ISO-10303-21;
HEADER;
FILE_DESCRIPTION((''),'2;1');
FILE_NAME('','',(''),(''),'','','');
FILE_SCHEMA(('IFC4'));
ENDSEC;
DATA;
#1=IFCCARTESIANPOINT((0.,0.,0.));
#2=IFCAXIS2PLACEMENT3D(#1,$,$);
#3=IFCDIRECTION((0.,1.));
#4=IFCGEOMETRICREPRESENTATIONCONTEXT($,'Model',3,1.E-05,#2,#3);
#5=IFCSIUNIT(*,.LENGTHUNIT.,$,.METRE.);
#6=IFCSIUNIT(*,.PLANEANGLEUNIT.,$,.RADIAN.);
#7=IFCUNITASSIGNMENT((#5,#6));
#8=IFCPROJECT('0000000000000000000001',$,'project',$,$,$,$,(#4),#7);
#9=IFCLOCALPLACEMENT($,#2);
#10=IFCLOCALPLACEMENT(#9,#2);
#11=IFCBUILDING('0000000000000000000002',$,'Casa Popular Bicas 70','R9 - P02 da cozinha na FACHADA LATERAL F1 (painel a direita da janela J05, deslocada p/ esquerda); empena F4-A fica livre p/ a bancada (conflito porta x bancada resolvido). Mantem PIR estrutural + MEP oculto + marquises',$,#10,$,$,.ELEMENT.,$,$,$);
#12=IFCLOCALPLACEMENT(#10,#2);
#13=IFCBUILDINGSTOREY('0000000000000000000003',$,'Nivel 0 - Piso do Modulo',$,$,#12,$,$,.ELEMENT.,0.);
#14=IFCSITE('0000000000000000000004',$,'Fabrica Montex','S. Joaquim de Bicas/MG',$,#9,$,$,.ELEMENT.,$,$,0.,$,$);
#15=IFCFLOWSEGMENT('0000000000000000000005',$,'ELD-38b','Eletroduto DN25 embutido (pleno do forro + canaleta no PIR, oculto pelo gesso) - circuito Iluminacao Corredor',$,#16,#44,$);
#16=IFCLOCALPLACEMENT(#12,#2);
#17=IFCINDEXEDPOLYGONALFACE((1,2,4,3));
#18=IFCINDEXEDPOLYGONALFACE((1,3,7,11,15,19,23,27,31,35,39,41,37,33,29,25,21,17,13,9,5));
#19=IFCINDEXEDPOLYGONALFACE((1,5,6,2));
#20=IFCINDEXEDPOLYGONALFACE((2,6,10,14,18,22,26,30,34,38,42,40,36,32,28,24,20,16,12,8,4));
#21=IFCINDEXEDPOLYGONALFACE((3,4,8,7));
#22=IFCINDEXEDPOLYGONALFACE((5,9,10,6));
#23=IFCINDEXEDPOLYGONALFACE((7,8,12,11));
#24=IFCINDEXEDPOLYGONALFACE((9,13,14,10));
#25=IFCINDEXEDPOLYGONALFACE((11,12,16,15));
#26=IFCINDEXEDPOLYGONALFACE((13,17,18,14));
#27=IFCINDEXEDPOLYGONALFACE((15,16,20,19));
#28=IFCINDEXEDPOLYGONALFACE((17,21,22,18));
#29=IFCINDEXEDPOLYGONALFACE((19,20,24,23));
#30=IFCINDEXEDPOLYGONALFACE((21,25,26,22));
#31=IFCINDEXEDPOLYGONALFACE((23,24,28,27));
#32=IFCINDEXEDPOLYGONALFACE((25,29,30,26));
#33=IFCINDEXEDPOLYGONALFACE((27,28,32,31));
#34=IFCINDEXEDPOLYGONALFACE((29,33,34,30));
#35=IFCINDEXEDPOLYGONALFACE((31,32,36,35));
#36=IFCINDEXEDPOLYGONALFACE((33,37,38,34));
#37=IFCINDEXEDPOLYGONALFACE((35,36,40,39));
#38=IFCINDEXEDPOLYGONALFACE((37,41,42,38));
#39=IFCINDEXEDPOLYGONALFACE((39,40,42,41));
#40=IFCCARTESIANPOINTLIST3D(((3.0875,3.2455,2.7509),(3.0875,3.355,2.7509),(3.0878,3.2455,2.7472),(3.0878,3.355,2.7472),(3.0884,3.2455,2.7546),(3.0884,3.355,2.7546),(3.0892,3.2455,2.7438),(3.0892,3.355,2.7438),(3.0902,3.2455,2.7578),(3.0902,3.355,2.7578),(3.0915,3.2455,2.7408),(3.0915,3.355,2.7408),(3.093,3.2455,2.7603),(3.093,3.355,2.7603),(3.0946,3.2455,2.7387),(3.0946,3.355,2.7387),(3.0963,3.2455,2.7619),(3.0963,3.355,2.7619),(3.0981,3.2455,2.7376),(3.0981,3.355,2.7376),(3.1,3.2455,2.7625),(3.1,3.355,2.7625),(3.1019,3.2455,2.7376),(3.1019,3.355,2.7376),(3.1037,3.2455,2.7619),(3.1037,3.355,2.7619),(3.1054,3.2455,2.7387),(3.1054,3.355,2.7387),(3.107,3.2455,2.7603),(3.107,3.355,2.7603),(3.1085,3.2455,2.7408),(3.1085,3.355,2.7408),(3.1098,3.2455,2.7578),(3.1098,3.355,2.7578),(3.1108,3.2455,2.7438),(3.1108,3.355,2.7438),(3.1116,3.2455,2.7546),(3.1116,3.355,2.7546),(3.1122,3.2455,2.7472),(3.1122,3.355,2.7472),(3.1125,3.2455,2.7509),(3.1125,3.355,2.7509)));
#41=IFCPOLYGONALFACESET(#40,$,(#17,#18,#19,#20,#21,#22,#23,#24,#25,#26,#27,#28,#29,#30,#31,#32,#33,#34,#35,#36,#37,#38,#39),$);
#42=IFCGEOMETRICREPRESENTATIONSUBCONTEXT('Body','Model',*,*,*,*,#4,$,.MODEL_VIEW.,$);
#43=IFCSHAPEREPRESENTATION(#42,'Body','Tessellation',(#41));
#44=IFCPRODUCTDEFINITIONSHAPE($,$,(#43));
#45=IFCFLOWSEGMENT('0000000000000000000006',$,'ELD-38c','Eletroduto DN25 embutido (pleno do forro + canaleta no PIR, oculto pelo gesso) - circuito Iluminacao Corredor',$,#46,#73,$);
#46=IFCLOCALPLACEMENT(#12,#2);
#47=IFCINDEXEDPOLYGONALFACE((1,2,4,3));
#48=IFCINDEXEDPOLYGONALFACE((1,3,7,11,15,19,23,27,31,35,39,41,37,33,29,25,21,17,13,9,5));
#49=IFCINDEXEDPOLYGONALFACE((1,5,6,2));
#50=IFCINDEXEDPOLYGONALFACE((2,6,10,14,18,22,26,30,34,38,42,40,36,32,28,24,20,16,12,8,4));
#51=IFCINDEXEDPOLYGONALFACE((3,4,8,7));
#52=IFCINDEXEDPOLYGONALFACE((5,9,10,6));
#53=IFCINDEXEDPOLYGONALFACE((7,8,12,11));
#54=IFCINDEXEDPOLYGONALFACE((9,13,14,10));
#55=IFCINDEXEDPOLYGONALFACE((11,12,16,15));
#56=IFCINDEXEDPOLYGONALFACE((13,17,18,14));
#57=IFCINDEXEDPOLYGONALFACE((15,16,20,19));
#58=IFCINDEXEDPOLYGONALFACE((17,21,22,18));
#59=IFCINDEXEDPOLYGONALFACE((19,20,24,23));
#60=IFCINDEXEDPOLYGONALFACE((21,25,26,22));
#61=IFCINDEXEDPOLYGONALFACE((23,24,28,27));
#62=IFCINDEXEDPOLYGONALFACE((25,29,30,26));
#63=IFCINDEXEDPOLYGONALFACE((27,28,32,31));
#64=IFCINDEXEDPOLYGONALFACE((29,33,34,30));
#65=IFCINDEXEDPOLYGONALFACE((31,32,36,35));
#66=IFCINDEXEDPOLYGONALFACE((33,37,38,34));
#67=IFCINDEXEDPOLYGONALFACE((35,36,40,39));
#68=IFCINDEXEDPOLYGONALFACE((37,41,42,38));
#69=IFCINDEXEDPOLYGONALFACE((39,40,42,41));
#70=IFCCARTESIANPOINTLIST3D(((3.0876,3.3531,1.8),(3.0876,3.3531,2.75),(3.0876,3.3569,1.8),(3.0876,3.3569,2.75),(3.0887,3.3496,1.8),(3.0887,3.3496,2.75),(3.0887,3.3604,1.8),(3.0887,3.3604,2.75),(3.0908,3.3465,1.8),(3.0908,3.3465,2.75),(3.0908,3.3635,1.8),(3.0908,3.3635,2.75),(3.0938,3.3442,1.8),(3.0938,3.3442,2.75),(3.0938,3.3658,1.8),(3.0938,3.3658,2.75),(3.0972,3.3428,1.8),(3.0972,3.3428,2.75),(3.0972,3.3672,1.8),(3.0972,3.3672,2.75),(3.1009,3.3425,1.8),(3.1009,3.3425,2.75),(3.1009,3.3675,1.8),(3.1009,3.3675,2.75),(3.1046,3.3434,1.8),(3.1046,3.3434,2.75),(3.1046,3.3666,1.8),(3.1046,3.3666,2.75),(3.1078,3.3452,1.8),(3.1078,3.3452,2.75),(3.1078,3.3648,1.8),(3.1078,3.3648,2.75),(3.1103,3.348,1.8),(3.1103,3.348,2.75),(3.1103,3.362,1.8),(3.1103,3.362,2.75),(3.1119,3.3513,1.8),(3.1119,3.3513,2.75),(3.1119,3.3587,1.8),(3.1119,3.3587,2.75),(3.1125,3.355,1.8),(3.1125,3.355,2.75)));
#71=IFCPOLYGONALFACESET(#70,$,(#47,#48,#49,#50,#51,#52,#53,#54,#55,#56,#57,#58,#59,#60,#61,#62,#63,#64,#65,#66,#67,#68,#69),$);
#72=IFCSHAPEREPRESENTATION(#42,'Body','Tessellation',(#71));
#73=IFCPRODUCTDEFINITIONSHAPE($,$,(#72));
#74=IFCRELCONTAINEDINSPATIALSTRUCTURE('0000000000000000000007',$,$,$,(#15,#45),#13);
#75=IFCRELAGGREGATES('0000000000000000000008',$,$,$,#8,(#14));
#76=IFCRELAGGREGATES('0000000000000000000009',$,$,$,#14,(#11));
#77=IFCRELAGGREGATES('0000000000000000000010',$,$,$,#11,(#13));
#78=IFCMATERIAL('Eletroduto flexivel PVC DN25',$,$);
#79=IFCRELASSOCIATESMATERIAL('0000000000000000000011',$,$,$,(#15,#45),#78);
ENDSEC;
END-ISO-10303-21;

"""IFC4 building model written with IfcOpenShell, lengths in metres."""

from ifc_helpers import new_model, si_unit, direction, frame, origin, origin_2d, place, context, subcontext, project, spatial, circle, extrude, material, element, save


model = new_model("IFC4")

# Units and contexts
model_context = context("Model", 3, precision=1e-05, world=origin(), true_north=direction((0.0, 1.0)))
body_context = subcontext(model_context, "Body", "Model", "MODEL_VIEW")
ifc_project = project(units=[si_unit("LENGTHUNIT", "METRE"), si_unit("PLANEANGLEUNIT", "RADIAN")], contexts=[model_context])

# Site, building, storey
site_placement = place(None, origin())
site = spatial("IfcSite", under=ifc_project, at=site_placement, Name="Fabrica Montex", Description="S. Joaquim de Bicas/MG", CompositionType="ELEMENT", RefElevation=0.0)
building_placement = place(site_placement, origin())
building = spatial("IfcBuilding", under=site, at=building_placement, Name="Casa Popular Bicas 70", Description="R9 - P02 da cozinha na FACHADA LATERAL F1 (painel a direita da janela J05, deslocada p/ esquerda); empena F4-A fica livre p/ a bancada (conflito porta x bancada resolvido). Mantem PIR estrutural + MEP oculto + marquises", CompositionType="ELEMENT")
storey_placement = place(building_placement, origin())
storey = spatial("IfcBuildingStorey", under=building, at=storey_placement, Name="Nivel 0 - Piso do Modulo", CompositionType="ELEMENT", Elevation=0.0)

# Flow segments
ifc_material_1 = material(Name="Eletroduto flexivel PVC DN25")
flow_segment_1_placement = place(storey_placement, frame((3.1, 3.2455, 2.75), z_axis=(0.0, 1.0, 0.0), x_axis=(0.0, 0.0, 1.0)))
element("IfcFlowSegment", 1, at=flow_segment_1_placement, inside=storey, material=ifc_material_1, Name="ELD-38b", Description="Eletroduto DN25 embutido (pleno do forro + canaleta no PIR, oculto pelo gesso) - circuito Iluminacao Corredor", context=body_context, shape_type="SweptSolid", body=[
    extrude(circle(Radius=0.0125, at=origin_2d()), origin(), (0.0, 0.0, 1.0), 0.1095),
])
flow_segment_2_placement = place(storey_placement, frame((3.1, 3.355, 2.75), z_axis=(0.0, 0.0, -1.0), x_axis=(1.0, 0.0, 0.0)))
element("IfcFlowSegment", 2, at=flow_segment_2_placement, inside=storey, material=ifc_material_1, Name="ELD-38c", Description="Eletroduto DN25 embutido (pleno do forro + canaleta no PIR, oculto pelo gesso) - circuito Iluminacao Corredor", context=body_context, shape_type="SweptSolid", body=[
    extrude(circle(Radius=0.0125, at=origin_2d()), origin(), (0.0, 0.0, 1.0), 0.95),
])

save(model, "model.ifc")
